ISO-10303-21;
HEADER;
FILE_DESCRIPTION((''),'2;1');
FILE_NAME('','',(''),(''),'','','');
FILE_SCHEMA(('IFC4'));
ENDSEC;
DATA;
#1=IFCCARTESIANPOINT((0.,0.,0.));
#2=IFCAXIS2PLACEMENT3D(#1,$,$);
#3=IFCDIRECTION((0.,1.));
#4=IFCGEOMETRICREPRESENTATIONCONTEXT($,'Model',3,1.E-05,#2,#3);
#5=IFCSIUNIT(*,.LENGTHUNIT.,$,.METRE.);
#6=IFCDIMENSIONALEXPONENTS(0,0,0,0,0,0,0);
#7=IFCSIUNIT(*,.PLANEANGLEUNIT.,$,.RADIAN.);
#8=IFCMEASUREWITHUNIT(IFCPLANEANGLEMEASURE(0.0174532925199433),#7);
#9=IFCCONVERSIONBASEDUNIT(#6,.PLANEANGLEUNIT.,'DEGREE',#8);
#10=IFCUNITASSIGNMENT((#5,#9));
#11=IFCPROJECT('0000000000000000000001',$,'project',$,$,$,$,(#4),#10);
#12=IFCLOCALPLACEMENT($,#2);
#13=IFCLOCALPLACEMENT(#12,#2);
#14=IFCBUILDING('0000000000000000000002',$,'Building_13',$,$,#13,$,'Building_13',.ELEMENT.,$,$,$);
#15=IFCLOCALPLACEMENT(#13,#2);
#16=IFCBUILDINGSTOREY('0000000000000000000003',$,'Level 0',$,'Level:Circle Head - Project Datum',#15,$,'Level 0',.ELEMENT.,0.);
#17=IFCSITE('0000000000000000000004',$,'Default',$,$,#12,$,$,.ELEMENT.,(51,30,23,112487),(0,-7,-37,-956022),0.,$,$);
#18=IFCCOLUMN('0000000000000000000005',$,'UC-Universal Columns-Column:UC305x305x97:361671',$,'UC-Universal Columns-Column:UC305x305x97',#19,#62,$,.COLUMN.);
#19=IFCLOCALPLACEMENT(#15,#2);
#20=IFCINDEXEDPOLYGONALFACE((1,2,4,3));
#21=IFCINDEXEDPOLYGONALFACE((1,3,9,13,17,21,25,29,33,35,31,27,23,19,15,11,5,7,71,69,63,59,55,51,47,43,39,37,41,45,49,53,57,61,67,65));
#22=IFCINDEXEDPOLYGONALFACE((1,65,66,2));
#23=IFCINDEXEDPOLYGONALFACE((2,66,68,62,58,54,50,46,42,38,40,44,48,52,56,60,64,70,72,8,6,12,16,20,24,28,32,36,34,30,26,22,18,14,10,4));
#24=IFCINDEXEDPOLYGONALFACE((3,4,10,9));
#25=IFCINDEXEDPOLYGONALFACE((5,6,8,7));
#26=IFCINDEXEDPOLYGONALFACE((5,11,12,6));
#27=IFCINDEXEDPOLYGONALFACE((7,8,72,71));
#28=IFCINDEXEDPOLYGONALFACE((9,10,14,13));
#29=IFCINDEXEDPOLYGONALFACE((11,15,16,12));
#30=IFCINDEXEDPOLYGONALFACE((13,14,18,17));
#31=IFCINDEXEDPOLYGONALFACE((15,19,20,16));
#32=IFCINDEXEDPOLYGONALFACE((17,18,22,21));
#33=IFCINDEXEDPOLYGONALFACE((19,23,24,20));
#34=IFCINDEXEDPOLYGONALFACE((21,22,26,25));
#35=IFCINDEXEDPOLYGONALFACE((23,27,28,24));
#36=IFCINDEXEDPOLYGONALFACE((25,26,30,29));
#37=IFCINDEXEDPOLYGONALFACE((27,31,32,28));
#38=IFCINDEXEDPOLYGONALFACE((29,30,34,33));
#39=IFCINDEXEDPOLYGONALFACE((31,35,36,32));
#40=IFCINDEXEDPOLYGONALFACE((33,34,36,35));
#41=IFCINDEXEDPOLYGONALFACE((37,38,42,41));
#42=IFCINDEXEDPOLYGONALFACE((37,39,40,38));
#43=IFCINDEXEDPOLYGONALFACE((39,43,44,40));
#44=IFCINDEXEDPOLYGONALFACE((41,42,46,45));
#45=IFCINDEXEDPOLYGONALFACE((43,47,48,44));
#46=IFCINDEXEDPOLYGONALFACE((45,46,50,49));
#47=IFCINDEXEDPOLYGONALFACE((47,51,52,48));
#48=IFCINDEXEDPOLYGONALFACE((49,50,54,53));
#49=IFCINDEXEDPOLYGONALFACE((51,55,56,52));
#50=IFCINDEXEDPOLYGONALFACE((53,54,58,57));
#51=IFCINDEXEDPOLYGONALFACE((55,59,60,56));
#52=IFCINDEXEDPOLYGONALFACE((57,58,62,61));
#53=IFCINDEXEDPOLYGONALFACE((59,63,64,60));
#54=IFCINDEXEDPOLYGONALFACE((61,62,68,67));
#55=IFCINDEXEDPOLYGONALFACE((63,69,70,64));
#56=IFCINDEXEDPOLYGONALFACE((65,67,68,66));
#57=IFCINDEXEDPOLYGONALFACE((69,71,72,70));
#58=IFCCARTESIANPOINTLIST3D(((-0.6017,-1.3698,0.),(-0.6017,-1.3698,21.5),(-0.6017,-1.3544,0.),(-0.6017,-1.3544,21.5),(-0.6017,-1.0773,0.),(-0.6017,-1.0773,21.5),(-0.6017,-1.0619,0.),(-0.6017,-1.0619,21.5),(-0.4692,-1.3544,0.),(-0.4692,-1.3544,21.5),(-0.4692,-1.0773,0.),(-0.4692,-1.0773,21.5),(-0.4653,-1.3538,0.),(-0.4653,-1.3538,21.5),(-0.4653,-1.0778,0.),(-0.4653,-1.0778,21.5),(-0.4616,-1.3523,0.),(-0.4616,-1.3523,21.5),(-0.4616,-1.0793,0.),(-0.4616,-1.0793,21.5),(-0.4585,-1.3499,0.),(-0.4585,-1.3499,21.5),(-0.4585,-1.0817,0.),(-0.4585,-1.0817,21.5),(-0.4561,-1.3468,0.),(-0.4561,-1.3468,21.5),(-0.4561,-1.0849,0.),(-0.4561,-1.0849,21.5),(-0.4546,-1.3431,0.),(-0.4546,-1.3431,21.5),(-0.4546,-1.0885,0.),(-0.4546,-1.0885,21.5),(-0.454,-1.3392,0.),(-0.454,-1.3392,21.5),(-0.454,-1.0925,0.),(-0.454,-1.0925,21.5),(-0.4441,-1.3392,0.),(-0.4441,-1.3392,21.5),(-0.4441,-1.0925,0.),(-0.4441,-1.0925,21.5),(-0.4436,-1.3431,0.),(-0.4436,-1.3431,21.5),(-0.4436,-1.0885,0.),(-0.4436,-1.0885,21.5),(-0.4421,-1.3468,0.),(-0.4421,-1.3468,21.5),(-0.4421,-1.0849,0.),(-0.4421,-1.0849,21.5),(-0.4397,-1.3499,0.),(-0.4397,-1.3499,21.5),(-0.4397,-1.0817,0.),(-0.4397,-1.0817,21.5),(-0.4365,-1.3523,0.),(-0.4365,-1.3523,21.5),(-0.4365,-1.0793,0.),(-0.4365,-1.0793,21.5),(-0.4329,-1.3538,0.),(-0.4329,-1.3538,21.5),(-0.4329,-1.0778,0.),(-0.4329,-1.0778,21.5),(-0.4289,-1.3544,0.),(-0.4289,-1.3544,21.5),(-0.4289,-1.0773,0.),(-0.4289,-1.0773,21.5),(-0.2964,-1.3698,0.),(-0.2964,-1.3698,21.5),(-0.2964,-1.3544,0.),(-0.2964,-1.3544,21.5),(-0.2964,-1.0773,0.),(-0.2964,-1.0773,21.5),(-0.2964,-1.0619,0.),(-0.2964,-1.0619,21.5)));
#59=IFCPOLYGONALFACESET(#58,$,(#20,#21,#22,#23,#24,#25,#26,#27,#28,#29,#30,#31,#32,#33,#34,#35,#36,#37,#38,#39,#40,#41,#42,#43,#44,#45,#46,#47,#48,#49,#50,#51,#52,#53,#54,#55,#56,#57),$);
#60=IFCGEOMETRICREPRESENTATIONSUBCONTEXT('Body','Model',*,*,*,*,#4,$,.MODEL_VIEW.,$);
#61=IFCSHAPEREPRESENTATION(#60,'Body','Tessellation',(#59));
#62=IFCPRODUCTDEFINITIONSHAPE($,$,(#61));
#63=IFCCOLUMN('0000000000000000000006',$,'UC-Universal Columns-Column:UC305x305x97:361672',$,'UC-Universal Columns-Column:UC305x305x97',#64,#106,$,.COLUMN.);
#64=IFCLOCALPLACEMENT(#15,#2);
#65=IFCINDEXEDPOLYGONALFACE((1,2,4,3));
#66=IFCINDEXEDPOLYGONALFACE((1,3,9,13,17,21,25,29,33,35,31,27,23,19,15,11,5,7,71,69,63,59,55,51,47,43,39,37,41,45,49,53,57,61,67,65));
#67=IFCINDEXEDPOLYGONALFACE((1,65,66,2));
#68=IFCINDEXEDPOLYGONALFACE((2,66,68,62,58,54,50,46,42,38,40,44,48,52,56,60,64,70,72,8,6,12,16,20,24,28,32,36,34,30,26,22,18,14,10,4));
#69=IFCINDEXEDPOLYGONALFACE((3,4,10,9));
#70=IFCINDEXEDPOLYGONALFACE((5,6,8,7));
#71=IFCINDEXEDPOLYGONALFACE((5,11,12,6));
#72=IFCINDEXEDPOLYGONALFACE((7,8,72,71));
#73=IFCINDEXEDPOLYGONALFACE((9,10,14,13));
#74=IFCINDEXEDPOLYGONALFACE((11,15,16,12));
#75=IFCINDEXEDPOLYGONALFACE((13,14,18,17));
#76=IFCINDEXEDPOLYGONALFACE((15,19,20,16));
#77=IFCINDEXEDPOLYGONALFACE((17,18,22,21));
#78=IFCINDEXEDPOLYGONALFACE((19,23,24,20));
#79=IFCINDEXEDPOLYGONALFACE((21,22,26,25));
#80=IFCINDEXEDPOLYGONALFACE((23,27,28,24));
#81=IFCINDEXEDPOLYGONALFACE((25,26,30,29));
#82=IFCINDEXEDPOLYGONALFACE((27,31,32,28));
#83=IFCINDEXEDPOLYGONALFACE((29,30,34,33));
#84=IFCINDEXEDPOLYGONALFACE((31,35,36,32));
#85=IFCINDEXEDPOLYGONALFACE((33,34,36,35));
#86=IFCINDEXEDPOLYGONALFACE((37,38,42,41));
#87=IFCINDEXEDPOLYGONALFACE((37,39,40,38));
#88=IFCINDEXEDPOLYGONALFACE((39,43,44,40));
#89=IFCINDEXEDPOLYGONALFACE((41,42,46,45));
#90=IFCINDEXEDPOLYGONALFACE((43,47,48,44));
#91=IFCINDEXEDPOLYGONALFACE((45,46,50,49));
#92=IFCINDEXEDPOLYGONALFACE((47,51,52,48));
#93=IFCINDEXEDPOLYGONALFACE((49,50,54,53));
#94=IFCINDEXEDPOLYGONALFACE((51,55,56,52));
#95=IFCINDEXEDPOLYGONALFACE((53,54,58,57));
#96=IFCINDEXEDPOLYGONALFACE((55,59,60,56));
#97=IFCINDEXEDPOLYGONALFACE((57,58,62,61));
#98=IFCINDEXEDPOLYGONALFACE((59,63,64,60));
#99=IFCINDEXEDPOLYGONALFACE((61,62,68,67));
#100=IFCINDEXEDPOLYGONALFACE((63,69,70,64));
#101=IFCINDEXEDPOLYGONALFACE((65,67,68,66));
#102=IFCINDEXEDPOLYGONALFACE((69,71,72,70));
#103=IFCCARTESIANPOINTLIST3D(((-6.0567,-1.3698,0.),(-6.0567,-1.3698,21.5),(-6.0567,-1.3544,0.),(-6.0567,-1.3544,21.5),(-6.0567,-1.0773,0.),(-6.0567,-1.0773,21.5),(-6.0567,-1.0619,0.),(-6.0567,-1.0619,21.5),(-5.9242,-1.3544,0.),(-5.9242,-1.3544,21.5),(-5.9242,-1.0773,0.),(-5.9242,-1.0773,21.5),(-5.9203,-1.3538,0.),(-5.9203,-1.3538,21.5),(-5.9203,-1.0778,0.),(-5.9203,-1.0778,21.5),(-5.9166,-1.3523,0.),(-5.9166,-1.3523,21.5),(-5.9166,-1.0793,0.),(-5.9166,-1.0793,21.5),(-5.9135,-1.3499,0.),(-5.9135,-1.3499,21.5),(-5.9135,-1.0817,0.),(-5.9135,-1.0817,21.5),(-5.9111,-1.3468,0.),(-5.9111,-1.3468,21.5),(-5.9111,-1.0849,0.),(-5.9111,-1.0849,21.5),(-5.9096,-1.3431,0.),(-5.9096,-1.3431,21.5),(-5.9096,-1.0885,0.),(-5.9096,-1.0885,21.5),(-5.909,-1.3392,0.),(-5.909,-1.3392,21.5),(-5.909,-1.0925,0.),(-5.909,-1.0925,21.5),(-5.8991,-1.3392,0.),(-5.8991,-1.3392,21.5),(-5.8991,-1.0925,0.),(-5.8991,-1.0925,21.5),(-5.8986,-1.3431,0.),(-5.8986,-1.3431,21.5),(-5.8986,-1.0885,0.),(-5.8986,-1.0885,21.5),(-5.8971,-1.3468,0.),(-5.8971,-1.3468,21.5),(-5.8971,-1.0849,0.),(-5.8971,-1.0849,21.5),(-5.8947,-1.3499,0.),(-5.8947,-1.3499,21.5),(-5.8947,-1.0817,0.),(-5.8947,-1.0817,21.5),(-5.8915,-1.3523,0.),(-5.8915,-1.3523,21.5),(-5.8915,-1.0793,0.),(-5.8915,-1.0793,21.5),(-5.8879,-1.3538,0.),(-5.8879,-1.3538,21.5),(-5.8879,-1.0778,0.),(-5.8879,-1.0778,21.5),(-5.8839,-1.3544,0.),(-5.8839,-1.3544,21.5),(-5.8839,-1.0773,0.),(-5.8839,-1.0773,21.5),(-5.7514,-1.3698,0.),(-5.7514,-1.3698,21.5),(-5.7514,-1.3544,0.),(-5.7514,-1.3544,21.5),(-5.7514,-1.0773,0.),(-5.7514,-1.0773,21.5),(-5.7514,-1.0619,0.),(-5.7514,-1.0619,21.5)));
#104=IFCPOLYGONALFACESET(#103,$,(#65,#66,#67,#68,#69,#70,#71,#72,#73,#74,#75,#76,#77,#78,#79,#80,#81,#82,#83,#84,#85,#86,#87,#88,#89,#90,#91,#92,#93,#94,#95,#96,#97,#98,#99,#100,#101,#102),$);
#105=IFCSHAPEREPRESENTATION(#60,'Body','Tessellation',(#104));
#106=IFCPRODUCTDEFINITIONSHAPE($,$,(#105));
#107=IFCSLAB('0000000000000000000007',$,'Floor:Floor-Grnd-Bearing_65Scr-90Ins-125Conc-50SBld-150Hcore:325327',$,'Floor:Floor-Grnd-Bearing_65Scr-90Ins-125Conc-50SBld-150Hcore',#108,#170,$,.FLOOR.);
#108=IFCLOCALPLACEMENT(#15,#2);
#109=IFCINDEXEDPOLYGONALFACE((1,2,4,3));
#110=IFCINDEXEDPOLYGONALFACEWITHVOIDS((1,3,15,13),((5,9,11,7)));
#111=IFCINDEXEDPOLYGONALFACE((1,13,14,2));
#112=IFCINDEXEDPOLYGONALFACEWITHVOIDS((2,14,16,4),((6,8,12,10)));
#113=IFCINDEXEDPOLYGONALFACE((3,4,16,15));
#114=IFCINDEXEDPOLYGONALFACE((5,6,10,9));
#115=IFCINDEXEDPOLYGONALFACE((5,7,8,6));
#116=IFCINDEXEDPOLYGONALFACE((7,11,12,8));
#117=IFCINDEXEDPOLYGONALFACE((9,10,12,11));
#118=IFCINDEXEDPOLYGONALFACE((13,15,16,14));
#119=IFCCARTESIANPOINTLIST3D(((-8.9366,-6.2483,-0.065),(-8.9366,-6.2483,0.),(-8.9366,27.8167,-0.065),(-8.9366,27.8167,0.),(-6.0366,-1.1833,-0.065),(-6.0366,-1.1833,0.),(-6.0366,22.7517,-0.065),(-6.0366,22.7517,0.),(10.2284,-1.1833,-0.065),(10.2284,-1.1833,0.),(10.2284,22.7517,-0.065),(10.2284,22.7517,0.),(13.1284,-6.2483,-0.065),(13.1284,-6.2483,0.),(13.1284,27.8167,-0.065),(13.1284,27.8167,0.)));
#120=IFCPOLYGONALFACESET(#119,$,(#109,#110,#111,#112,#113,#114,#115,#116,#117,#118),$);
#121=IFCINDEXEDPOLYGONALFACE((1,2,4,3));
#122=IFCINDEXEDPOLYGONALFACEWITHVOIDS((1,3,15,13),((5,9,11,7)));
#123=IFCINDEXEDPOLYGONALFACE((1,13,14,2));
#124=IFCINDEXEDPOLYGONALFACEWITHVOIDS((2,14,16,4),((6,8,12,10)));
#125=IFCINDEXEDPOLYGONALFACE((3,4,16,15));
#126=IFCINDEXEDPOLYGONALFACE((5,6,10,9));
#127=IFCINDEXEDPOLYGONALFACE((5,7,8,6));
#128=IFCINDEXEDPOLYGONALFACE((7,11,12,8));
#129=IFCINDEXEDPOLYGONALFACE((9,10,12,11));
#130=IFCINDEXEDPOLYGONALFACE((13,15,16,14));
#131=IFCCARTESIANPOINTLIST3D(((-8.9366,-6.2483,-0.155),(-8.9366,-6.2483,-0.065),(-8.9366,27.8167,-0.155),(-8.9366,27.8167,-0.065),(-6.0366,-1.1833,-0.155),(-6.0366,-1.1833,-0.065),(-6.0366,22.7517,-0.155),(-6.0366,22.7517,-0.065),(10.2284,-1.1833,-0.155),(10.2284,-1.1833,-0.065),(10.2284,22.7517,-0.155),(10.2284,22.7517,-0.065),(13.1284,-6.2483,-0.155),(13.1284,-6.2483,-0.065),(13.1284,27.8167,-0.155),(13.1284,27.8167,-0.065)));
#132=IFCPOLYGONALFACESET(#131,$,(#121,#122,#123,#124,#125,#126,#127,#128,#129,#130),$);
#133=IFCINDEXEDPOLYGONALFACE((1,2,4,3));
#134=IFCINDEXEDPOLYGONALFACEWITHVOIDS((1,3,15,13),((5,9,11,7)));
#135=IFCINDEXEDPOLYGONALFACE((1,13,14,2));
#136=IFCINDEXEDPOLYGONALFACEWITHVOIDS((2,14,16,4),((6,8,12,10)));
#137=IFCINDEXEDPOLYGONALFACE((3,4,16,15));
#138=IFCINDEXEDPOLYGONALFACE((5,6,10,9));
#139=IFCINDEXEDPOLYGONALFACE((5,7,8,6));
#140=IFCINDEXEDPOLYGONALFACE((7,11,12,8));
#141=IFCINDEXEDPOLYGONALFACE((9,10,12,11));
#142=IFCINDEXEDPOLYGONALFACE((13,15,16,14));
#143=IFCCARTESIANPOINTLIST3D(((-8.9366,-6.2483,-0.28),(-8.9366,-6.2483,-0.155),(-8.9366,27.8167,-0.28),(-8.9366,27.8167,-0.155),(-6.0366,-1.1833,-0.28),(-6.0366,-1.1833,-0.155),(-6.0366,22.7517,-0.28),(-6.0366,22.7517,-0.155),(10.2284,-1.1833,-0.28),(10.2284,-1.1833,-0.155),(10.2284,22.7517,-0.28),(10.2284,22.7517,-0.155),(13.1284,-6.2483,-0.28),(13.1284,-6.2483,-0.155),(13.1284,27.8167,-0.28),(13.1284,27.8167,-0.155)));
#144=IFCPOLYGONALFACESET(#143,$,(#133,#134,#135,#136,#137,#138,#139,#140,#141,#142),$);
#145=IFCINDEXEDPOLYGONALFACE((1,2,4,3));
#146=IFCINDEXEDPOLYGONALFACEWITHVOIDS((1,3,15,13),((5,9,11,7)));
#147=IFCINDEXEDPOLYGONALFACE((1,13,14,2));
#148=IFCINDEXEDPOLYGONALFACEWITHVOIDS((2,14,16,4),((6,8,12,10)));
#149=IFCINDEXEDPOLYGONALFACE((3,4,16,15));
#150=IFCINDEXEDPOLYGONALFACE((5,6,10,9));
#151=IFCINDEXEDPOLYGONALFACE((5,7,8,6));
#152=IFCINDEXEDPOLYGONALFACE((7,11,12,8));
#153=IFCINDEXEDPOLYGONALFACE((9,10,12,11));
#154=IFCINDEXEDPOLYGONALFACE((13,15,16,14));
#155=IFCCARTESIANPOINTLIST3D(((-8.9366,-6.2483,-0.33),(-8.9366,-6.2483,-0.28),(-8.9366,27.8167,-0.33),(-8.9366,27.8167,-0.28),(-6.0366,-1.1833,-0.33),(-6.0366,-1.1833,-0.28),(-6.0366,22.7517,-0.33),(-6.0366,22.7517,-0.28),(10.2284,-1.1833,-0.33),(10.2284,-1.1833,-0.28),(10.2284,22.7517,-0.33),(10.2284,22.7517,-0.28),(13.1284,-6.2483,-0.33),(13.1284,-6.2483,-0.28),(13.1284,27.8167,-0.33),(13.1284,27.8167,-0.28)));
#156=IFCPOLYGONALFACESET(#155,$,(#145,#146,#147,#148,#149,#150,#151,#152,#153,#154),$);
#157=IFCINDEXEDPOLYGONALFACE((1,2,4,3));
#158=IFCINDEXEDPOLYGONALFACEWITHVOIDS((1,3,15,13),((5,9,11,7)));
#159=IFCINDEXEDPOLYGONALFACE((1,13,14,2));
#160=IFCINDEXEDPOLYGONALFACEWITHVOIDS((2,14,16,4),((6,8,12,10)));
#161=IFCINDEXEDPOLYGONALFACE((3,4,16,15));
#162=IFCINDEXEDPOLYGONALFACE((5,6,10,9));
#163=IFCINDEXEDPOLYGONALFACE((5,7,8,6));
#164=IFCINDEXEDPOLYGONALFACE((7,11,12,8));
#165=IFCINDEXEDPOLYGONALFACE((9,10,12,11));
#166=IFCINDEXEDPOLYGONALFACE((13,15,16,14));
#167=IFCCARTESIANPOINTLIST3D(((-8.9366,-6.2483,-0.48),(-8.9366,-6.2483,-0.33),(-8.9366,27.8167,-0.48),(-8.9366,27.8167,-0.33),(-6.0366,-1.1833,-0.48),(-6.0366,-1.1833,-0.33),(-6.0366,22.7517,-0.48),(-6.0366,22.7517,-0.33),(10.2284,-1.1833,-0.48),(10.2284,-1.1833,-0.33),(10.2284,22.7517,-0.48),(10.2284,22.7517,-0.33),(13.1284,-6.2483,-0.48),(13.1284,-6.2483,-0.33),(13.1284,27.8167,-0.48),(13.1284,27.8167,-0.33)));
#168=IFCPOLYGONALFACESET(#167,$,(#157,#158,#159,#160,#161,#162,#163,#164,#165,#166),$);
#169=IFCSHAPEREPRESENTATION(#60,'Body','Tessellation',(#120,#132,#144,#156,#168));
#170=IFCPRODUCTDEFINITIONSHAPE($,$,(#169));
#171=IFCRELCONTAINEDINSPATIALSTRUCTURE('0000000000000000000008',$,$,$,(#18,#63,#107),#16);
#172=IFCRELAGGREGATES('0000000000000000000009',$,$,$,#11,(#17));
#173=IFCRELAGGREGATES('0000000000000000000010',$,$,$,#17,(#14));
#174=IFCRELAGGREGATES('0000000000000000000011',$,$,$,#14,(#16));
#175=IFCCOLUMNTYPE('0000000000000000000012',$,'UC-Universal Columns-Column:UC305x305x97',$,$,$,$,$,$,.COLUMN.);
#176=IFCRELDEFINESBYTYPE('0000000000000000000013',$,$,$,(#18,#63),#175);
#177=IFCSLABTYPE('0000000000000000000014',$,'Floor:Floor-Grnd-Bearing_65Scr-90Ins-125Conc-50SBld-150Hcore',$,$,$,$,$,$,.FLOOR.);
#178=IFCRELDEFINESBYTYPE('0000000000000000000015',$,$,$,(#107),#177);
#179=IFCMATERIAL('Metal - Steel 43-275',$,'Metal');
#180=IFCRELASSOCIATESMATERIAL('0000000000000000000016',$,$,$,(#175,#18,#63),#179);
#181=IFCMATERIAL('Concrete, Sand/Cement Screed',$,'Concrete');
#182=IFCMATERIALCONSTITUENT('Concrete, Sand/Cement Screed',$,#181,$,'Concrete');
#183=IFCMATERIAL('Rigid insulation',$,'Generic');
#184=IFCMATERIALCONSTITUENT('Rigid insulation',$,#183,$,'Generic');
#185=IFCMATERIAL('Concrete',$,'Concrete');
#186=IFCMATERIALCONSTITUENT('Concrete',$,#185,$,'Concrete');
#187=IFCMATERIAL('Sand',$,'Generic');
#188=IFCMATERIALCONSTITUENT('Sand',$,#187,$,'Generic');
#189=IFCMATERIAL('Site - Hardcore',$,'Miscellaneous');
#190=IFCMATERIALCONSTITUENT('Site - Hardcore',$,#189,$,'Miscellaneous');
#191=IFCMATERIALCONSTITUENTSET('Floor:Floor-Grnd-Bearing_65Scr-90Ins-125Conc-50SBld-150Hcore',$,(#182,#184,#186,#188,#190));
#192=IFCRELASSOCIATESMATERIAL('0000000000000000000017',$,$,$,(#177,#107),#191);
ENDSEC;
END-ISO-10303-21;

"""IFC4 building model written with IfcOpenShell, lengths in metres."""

from ifc_helpers import new_model, entity, si_unit, converted_unit, direction, frame, origin, place, context, subcontext, project, spatial, line, arc, indexed_curve, outline, extrude, source, transform, mapped, material, constituent, constituent_set, type_object, type_shapes, element, save


model = new_model("IFC4")

# Units and contexts
model_context = context("Model", 3, precision=1e-05, world=origin(), true_north=direction((0.0, 1.0)))
body_context = subcontext(model_context, "Body", "Model", "MODEL_VIEW")
ifc_project = project(units=[si_unit("LENGTHUNIT", "METRE"), converted_unit("PLANEANGLEUNIT", "DEGREE", entity("IfcPlaneAngleMeasure", 0.0174532925199433), si_unit("PLANEANGLEUNIT", "RADIAN"), dimensions=[0, 0, 0, 0, 0, 0, 0])], contexts=[model_context])

# Site, building, storey
site_placement = place(None, origin())
site = spatial("IfcSite", under=ifc_project, at=site_placement, Name="Default", CompositionType="ELEMENT", RefLatitude=(51, 30, 23, 112487), RefLongitude=(0, -7, -37, -956022), RefElevation=0.0)
building_placement = place(site_placement, origin())
building = spatial("IfcBuilding", under=site, at=building_placement, Name="Building_13", LongName="Building_13", CompositionType="ELEMENT")
storey_placement = place(building_placement, origin())
storey = spatial("IfcBuildingStorey", under=building, at=storey_placement, Name="Level 0", ObjectType="Level:Circle Head - Project Datum", LongName="Level 0", CompositionType="ELEMENT", Elevation=0.0)

# Columns
ifc_material_1 = material(Name="Metal - Steel 43-275", Category="Metal")
column_type_1 = type_object("IfcColumnType", Name="UC-Universal Columns-Column:UC305x305x97", PredefinedType="COLUMN", material=ifc_material_1)
shared_shape_1 = source(origin(), body_context, "Body", "SweptSolid", [
    extrude(outline(indexed_curve([(-0.154, -0.1527), (-0.1386, -0.1527), (-0.1386, -0.0201), (-0.1341, -0.0094), (-0.1234, -0.005), (0.1234, -0.005), (0.1341, -0.0094), (0.1386, -0.0202), (0.1386, -0.1527), (0.154, -0.1527), (0.154, 0.1527), (0.1386, 0.1527), (0.1386, 0.0201), (0.1341, 0.0094), (0.1234, 0.0049), (-0.1234, 0.0049), (-0.1341, 0.0094), (-0.1386, 0.0202), (-0.1386, 0.1527), (-0.154, 0.1527)], segments=[line(1, 2, 3), arc(3, 4, 5), line(5, 6), arc(6, 7, 8), line(8, 9, 10, 11, 12, 13), arc(13, 14, 15), line(15, 16), arc(16, 17, 18), line(18, 19, 20, 1)], self_intersect=False)), frame((0.0, 0.0, 0.0), z_axis=(0.0, 0.0, 1.0), x_axis=(0.0, 1.0, 0.0)), (0.0, 0.0, 1.0), 21.5),
])
type_shapes(column_type_1, [shared_shape_1])
for number, where, name in (
    (1, (-0.4491, -1.2158, 0.0), "UC-Universal Columns-Column:UC305x305x97:361671"),
    (2, (-5.9041, -1.2158, 0.0), "UC-Universal Columns-Column:UC305x305x97:361672"),
):
    element("IfcColumn", number, at=place(storey_placement, frame(where)), inside=storey, type_object=column_type_1, material=ifc_material_1, Name=name, ObjectType="UC-Universal Columns-Column:UC305x305x97", PredefinedType="COLUMN", context=body_context, shape_type="MappedRepresentation", body=[
        mapped(shared_shape_1, transform((0.0, 0.0, 0.0), scale=1.0)),
    ])

# Slab, opening
ifc_material_2 = material(Name="Concrete, Sand/Cement Screed", Category="Concrete")
ifc_constituent_1 = constituent(ifc_material_2, Name="Concrete, Sand/Cement Screed", Category="Concrete")
ifc_material_3 = material(Name="Rigid insulation", Category="Generic")
ifc_constituent_2 = constituent(ifc_material_3, Name="Rigid insulation", Category="Generic")
ifc_material_4 = material(Name="Concrete", Category="Concrete")
ifc_constituent_3 = constituent(ifc_material_4, Name="Concrete", Category="Concrete")
ifc_material_5 = material(Name="Sand", Category="Generic")
ifc_constituent_4 = constituent(ifc_material_5, Name="Sand", Category="Generic")
ifc_material_6 = material(Name="Site - Hardcore", Category="Miscellaneous")
ifc_constituent_5 = constituent(ifc_material_6, Name="Site - Hardcore", Category="Miscellaneous")
ifc_constituent_set_1 = constituent_set(constituents=[ifc_constituent_1, ifc_constituent_2, ifc_constituent_3, ifc_constituent_4, ifc_constituent_5], Name="Floor:Floor-Grnd-Bearing_65Scr-90Ins-125Conc-50SBld-150Hcore")
slab_type = type_object("IfcSlabType", Name="Floor:Floor-Grnd-Bearing_65Scr-90Ins-125Conc-50SBld-150Hcore", PredefinedType="FLOOR", material=ifc_constituent_set_1)
slab_placement = place(storey_placement, origin())
slab = element("IfcSlab", 3, at=slab_placement, inside=storey, type_object=slab_type, material=ifc_constituent_set_1, Name="Floor:Floor-Grnd-Bearing_65Scr-90Ins-125Conc-50SBld-150Hcore:325327", ObjectType="Floor:Floor-Grnd-Bearing_65Scr-90Ins-125Conc-50SBld-150Hcore", PredefinedType="FLOOR", context=body_context, shape_type="SweptSolid", body=[
    extrude(outline(indexed_curve([(8.0, -17.0325), (11.0325, -17.0325), (11.0325, 17.0325), (8.0, 17.0325), (-8.0, 17.0325), (-11.0325, 17.0325), (-11.0325, -17.0325), (-8.0, -17.0325), (8.0, -17.0325)], self_intersect=False), holes=[indexed_curve([(-8.1325, -11.9675), (-8.1325, 11.9675), (8.1325, 11.9675), (8.1325, -11.9675), (-8.1325, -11.9675)], self_intersect=False)]), frame((2.0959, 10.7842, -0.065), z_axis=(0.0, 0.0, 1.0), x_axis=(-1.0, 0.0, 0.0)), (0.0, 0.0, 1.0), 0.065),
    extrude(outline(indexed_curve([(8.0, -17.0325), (11.0325, -17.0325), (11.0325, 17.0325), (8.0, 17.0325), (-8.0, 17.0325), (-11.0325, 17.0325), (-11.0325, -17.0325), (-8.0, -17.0325), (8.0, -17.0325)], self_intersect=False), holes=[indexed_curve([(-8.1325, -11.9675), (-8.1325, 11.9675), (8.1325, 11.9675), (8.1325, -11.9675), (-8.1325, -11.9675)], self_intersect=False)]), frame((2.0959, 10.7842, -0.155), z_axis=(0.0, 0.0, 1.0), x_axis=(-1.0, 0.0, 0.0)), (0.0, 0.0, 1.0), 0.09),
    extrude(outline(indexed_curve([(8.0, -17.0325), (11.0325, -17.0325), (11.0325, 17.0325), (8.0, 17.0325), (-8.0, 17.0325), (-11.0325, 17.0325), (-11.0325, -17.0325), (-8.0, -17.0325), (8.0, -17.0325)], self_intersect=False), holes=[indexed_curve([(-8.1325, -11.9675), (-8.1325, 11.9675), (8.1325, 11.9675), (8.1325, -11.9675), (-8.1325, -11.9675)], self_intersect=False)]), frame((2.0959, 10.7842, -0.28), z_axis=(0.0, 0.0, 1.0), x_axis=(-1.0, 0.0, 0.0)), (0.0, 0.0, 1.0), 0.125),
    extrude(outline(indexed_curve([(8.0, -17.0325), (11.0325, -17.0325), (11.0325, 17.0325), (8.0, 17.0325), (-8.0, 17.0325), (-11.0325, 17.0325), (-11.0325, -17.0325), (-8.0, -17.0325), (8.0, -17.0325)], self_intersect=False), holes=[indexed_curve([(-8.1325, -11.9675), (-8.1325, 11.9675), (8.1325, 11.9675), (8.1325, -11.9675), (-8.1325, -11.9675)], self_intersect=False)]), frame((2.0959, 10.7842, -0.33), z_axis=(0.0, 0.0, 1.0), x_axis=(-1.0, 0.0, 0.0)), (0.0, 0.0, 1.0), 0.05),
    extrude(outline(indexed_curve([(8.0, -17.0325), (11.0325, -17.0325), (11.0325, 17.0325), (8.0, 17.0325), (-8.0, 17.0325), (-11.0325, 17.0325), (-11.0325, -17.0325), (-8.0, -17.0325), (8.0, -17.0325)], self_intersect=False), holes=[indexed_curve([(-8.1325, -11.9675), (-8.1325, 11.9675), (8.1325, 11.9675), (8.1325, -11.9675), (-8.1325, -11.9675)], self_intersect=False)]), frame((2.0959, 10.7842, -0.48), z_axis=(0.0, 0.0, 1.0), x_axis=(-1.0, 0.0, 0.0)), (0.0, 0.0, 1.0), 0.15),
])
opening_1_placement = place(slab_placement, origin())
element("IfcOpeningElement", 4, at=opening_1_placement, cuts=slab, PredefinedType="OPENING", context=body_context, shape_type="SweptSolid", body=[
    extrude(outline(indexed_curve([(-11.9675, -8.1325), (11.9675, -8.1325), (11.9675, 8.1325), (-11.9675, 8.1325), (-11.9675, -8.1325)], self_intersect=False)), frame((2.0959, 10.7842, 0.0), z_axis=(0.0, 0.0, -1.0), x_axis=(0.0, -1.0, 0.0)), (0.0, 0.0, 1.0), 0.48),
])

save(model, "model.ifc")
